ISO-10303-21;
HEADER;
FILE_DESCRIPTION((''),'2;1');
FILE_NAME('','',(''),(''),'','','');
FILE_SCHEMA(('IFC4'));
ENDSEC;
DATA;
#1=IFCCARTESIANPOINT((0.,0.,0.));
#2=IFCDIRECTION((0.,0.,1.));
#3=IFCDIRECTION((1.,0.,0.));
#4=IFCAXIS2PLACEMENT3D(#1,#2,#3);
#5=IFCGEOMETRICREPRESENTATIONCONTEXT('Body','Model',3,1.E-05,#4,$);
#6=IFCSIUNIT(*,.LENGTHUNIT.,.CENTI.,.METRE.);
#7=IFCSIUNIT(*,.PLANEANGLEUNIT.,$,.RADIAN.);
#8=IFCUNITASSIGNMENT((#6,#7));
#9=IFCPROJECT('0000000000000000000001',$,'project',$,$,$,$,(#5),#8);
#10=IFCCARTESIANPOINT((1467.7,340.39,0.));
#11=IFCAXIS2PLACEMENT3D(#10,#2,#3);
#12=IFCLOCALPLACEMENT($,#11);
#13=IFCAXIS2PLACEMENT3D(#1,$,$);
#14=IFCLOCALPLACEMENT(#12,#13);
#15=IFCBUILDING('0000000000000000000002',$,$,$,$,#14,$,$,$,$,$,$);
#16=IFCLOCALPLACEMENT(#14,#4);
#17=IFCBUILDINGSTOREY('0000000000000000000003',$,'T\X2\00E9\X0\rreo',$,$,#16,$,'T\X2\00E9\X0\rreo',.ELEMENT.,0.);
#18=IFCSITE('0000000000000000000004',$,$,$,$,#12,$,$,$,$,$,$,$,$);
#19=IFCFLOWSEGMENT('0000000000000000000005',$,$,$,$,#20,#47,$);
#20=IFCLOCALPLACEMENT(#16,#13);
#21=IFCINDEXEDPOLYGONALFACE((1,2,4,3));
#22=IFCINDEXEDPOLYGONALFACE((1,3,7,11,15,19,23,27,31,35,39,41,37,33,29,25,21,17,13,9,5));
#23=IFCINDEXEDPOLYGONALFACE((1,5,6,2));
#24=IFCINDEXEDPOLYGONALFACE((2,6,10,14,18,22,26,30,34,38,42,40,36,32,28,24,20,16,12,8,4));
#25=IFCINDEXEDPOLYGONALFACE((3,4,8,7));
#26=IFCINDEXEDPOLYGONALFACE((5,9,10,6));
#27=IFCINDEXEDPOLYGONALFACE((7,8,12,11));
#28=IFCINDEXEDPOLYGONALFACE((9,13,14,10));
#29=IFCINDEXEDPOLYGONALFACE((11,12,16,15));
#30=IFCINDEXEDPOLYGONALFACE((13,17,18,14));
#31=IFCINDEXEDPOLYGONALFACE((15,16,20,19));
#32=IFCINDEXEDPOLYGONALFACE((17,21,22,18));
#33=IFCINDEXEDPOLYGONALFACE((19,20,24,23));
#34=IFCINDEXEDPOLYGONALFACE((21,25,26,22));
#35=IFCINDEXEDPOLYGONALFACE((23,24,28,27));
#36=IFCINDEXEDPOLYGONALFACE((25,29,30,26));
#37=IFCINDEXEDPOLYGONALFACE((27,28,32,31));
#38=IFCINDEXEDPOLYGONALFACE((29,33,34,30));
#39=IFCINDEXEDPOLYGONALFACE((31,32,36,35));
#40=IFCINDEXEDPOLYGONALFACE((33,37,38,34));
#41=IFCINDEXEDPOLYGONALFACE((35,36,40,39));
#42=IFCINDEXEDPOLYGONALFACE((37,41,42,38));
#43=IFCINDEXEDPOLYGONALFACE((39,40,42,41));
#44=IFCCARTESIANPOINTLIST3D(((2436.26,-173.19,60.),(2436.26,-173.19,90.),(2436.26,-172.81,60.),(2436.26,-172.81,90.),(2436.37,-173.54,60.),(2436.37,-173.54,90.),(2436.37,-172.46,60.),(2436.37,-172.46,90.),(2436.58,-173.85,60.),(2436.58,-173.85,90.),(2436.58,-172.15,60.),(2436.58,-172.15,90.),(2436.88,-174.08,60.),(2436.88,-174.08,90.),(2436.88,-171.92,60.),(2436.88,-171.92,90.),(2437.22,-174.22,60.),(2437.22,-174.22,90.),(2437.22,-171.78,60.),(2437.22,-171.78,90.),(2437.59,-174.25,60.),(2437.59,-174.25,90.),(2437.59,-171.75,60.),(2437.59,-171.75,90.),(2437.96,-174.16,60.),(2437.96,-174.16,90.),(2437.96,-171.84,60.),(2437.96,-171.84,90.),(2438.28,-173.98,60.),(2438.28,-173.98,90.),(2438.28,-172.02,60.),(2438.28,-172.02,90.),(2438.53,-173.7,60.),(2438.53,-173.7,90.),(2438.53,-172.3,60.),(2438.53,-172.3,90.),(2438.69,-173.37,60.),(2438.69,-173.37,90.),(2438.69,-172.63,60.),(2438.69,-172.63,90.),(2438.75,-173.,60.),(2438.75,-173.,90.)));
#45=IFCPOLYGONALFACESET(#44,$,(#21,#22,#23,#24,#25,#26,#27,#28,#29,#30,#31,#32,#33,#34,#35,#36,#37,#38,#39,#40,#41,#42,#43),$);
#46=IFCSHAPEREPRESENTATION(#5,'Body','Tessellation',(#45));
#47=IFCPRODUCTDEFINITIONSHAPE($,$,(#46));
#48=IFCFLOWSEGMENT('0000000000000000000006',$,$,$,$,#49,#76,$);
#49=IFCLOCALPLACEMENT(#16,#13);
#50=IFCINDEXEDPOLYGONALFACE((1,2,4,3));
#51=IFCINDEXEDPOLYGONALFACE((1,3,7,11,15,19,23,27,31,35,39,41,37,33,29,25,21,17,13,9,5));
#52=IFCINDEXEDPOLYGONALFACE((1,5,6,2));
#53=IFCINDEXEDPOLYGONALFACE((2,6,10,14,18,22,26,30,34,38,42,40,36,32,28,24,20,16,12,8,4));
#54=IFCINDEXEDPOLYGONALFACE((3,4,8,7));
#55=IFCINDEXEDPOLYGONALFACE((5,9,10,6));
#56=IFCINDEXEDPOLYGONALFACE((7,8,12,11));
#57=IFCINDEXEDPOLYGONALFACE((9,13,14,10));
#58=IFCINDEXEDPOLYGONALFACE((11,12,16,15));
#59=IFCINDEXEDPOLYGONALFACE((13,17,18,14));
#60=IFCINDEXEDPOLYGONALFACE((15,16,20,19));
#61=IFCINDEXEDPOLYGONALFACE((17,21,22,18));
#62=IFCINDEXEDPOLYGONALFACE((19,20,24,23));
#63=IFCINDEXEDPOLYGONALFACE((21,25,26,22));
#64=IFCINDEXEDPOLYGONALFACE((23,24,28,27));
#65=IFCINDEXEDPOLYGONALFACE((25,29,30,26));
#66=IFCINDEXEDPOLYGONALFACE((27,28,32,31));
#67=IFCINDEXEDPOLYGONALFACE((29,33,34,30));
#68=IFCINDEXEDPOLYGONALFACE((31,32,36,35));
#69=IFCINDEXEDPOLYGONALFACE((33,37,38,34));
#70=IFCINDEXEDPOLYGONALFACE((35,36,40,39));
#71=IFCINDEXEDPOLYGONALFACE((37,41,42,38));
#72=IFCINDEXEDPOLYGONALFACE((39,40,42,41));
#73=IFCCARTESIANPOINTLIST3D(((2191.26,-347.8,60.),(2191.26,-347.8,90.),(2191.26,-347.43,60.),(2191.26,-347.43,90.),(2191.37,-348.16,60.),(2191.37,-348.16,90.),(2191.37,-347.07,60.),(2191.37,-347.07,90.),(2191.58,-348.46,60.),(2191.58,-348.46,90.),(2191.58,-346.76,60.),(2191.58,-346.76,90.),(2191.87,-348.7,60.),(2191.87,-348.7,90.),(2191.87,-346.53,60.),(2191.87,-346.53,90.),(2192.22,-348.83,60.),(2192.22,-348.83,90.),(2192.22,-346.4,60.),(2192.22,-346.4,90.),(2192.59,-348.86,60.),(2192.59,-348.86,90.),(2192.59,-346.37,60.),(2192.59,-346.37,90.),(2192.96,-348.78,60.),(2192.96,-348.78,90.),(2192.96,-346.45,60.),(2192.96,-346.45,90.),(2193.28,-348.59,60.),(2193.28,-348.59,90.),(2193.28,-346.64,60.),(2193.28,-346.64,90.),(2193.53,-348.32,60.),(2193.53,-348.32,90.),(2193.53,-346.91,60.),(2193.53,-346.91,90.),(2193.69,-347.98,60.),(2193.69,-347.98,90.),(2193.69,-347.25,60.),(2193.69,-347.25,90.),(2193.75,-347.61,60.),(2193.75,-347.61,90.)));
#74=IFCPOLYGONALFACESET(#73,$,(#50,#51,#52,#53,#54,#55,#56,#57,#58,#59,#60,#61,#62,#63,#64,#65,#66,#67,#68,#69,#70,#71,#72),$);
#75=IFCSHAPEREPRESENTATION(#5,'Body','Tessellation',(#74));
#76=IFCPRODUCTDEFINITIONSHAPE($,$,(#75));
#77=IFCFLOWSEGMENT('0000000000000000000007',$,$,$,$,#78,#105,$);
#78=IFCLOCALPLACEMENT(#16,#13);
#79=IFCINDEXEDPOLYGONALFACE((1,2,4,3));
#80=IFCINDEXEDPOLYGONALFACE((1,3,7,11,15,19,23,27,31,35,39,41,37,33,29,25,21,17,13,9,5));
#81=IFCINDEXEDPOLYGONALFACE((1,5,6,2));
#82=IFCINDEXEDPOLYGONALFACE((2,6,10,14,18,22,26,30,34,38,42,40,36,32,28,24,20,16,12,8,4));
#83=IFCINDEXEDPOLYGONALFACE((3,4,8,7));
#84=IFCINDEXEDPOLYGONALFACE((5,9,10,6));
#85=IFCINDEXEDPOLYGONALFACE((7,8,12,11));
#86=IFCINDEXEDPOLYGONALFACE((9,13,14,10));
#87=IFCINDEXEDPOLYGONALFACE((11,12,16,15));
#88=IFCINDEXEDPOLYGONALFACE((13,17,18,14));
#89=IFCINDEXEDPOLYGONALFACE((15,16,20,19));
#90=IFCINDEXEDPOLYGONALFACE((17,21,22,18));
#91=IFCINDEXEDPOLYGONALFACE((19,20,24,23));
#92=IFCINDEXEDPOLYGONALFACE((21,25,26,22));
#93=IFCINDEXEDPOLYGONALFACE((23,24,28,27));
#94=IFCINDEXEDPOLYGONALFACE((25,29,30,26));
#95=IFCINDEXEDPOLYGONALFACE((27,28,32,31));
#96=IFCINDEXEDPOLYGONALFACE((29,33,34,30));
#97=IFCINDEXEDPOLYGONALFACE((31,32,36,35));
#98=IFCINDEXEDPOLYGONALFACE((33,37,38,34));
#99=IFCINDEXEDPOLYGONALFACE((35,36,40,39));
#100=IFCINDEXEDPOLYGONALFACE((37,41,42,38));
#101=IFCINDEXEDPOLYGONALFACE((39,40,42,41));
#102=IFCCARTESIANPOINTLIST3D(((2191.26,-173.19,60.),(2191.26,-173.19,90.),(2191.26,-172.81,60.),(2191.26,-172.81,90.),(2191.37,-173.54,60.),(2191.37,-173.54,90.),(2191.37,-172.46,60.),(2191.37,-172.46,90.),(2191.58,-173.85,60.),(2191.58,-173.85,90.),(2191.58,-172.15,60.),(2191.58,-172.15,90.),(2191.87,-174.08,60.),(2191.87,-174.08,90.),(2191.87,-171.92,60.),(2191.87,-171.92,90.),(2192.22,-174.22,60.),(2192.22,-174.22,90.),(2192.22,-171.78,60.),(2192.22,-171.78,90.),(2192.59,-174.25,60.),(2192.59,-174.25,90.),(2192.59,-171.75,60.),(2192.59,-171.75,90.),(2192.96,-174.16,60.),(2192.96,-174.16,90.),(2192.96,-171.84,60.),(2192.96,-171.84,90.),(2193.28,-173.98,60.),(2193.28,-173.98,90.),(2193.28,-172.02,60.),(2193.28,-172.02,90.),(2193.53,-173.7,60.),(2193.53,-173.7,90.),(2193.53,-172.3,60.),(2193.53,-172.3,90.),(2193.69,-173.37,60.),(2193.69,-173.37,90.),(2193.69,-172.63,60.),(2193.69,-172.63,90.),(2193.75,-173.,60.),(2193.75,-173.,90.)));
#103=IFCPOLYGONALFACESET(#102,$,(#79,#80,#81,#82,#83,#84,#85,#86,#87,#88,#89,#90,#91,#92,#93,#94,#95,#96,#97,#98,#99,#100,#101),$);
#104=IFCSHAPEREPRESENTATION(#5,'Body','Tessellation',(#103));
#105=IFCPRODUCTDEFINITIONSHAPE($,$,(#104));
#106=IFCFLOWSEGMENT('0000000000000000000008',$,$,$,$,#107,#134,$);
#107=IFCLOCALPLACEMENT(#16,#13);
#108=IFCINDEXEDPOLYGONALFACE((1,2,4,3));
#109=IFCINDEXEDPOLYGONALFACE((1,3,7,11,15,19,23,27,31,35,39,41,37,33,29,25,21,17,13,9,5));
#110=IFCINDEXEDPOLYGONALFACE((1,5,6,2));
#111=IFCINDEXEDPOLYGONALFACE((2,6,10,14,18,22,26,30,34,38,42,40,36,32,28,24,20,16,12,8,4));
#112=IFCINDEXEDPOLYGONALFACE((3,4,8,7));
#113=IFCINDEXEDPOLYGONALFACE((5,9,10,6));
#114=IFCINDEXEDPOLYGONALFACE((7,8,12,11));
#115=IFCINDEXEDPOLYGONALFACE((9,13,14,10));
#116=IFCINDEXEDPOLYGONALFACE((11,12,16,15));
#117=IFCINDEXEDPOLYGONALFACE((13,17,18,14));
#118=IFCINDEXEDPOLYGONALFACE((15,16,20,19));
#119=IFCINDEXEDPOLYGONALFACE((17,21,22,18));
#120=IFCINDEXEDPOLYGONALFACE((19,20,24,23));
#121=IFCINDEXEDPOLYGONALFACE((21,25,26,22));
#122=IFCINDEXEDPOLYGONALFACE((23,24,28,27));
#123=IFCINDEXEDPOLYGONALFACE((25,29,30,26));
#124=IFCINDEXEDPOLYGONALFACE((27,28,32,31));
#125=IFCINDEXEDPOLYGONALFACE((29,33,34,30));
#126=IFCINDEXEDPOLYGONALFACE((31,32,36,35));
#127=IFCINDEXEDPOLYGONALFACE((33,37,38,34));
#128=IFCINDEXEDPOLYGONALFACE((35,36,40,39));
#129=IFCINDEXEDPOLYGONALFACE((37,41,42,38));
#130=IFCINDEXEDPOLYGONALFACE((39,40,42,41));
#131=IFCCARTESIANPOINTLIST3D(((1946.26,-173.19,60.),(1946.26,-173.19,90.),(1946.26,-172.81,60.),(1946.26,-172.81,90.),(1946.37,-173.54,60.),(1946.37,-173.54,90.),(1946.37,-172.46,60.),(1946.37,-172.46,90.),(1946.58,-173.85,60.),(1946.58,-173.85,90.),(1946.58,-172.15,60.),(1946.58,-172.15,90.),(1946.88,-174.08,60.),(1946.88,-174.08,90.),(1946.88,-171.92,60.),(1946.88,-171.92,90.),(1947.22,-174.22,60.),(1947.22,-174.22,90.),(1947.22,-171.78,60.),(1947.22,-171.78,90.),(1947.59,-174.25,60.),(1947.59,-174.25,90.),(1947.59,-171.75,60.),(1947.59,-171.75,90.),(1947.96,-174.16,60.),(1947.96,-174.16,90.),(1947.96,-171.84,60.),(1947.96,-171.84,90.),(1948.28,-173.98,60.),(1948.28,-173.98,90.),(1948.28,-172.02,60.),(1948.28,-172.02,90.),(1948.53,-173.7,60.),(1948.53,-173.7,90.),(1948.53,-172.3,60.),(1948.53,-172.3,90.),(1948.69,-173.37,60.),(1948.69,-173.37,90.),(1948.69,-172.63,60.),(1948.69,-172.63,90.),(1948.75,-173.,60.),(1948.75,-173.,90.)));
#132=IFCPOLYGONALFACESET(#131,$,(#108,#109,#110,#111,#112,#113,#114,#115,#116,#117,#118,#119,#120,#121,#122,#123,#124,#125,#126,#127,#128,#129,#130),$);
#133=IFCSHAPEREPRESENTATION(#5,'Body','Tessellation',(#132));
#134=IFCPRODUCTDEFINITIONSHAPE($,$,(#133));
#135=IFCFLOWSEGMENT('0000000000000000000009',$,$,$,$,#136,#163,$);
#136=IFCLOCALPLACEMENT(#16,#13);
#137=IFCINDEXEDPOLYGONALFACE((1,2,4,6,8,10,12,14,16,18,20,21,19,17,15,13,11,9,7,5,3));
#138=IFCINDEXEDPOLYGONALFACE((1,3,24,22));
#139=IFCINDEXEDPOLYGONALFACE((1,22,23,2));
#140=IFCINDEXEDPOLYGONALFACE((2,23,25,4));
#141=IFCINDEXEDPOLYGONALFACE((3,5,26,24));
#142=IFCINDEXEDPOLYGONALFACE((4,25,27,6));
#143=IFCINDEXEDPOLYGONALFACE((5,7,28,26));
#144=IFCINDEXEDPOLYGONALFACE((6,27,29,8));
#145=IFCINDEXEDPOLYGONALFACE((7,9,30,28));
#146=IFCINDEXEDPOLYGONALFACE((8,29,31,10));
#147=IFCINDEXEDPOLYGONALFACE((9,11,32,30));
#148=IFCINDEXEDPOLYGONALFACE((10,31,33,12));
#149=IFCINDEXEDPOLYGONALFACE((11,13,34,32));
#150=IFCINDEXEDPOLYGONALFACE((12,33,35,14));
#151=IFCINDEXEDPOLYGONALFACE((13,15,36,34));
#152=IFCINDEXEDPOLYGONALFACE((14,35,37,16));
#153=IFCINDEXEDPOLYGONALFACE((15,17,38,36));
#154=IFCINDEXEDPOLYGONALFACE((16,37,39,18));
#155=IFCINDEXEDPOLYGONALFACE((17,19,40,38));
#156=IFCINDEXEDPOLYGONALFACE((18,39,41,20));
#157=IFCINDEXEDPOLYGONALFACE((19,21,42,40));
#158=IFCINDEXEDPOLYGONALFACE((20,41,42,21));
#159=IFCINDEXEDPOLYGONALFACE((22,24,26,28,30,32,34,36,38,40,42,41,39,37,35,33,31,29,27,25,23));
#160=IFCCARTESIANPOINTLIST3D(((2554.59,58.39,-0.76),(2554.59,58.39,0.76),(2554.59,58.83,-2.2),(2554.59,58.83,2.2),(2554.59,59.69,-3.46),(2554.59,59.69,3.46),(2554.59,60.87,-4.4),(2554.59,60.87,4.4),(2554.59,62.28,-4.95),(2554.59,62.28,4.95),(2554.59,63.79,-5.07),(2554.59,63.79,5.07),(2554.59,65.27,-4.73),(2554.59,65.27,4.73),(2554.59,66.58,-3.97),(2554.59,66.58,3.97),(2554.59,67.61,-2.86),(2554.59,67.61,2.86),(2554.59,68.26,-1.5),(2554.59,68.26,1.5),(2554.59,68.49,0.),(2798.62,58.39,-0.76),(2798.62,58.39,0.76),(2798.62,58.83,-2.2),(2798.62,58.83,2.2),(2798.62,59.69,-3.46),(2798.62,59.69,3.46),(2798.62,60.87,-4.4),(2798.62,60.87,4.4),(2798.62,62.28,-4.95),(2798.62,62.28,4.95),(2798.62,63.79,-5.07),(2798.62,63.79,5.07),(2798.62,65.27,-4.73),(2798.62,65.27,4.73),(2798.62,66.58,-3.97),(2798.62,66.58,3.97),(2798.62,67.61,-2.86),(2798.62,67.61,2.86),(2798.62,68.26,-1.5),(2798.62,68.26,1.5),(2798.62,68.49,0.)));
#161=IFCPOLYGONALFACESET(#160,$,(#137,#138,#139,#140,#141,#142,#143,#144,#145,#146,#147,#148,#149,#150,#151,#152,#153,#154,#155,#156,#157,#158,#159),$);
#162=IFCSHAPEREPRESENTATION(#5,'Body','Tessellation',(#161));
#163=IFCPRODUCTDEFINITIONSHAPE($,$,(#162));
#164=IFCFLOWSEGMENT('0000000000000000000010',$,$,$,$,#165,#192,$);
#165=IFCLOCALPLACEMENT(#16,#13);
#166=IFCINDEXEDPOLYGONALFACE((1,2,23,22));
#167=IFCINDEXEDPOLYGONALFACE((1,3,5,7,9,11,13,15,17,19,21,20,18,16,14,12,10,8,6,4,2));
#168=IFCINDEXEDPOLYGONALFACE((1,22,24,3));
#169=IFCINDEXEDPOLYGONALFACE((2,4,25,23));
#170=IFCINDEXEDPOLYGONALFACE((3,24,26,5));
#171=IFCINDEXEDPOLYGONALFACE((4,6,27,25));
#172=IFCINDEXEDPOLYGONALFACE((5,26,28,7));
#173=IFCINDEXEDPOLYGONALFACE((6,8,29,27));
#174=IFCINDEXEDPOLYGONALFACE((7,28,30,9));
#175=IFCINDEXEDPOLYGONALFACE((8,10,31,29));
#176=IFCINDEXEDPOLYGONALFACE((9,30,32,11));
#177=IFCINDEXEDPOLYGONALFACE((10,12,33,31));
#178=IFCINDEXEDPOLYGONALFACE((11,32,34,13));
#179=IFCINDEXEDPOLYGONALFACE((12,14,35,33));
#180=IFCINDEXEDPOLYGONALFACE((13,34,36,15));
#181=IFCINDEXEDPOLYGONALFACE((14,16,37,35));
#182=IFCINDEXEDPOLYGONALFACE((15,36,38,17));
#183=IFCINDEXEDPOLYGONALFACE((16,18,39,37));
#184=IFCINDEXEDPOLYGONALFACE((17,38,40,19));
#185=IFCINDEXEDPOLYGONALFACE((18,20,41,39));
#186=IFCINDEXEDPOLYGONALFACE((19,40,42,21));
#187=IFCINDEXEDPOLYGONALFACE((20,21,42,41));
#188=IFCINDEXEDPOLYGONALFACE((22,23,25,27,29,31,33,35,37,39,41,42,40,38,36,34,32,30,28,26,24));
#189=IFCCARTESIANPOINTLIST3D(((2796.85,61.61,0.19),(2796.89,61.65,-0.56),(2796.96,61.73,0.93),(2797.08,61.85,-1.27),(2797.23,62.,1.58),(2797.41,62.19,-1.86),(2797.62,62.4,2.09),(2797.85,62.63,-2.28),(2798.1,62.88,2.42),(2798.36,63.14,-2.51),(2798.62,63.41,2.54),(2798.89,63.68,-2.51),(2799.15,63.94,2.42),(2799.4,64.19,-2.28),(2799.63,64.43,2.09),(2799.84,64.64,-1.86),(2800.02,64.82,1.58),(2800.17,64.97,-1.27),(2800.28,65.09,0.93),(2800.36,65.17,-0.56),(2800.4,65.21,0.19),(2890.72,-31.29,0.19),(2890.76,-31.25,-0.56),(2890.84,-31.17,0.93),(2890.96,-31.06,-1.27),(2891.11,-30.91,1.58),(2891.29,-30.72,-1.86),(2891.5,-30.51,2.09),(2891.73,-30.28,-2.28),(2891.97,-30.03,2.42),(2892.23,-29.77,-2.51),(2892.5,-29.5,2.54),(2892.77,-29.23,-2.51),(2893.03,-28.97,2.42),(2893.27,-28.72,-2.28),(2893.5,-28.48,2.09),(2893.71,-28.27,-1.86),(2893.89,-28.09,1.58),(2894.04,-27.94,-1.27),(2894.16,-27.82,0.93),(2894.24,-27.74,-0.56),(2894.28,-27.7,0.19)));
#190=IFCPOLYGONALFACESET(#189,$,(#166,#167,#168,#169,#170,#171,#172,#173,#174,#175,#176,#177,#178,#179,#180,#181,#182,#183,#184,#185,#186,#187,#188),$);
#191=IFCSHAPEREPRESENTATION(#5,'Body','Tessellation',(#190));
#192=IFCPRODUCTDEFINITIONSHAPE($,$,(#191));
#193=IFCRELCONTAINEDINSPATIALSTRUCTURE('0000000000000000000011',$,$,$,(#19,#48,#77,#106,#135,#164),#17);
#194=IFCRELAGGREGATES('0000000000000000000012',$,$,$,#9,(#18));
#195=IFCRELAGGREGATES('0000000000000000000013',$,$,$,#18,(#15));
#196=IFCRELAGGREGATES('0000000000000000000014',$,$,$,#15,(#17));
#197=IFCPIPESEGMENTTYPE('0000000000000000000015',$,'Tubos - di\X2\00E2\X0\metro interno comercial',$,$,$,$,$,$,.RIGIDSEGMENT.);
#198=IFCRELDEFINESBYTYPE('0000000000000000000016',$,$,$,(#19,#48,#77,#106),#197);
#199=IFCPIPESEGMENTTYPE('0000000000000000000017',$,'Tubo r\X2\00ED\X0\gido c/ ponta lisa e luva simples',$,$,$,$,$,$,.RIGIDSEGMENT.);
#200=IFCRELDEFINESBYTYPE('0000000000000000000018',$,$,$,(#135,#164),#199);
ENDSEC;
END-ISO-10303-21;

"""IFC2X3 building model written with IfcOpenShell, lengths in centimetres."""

from ifc_helpers import new_model, si_unit, frame, origin, origin_with_axes, origin_2d_with_axis, place, context, project, spatial, circle, extrude, type_object, element, save


model = new_model("IFC2X3")

# Units and contexts
model_context = context("Model", 3, precision=1e-05, world=origin_with_axes(), identifier="Body")
ifc_project = project(units=[si_unit("LENGTHUNIT", "METRE", prefix="CENTI"), si_unit("PLANEANGLEUNIT", "RADIAN")], contexts=[model_context])

# Site, building, storey
site_placement = place(None, frame((1467.7, 340.39, 0.0), z_axis=(0.0, 0.0, 1.0), x_axis=(1.0, 0.0, 0.0)))
site = spatial("IfcSite", under=ifc_project, at=site_placement)
building_placement = place(site_placement, origin())
building = spatial("IfcBuilding", under=site, at=building_placement)
storey_placement = place(building_placement, origin_with_axes())
storey = spatial("IfcBuildingStorey", under=building, at=storey_placement, Name="Térreo", LongName="Térreo", CompositionType="ELEMENT", Elevation=0.0)

# Flow segments
pipe_segment_type_1 = type_object("IfcPipeSegmentType", Name="Tubos - diâmetro interno comercial", PredefinedType="RIGIDSEGMENT")
for number, where, z_axis, x_axis in (
    (1, (2437.5, -173.0, 90.0), (0.0, 0.0, 1.0), (1.0, 0.0, 0.0)),
    (2, (2192.5, -347.61, 90.0), (0.0, 0.0, 1.0), (1.0, 0.0, 0.0)),
    (3, (2192.5, -173.0, 90.0), (0.0, 0.0, 1.0), (1.0, 0.0, 0.0)),
    (4, (1947.5, -173.0, 90.0), (0.0, 0.0, 1.0), (1.0, 0.0, 0.0)),
):
    element("IfcFlowSegment", number, at=place(storey_placement, frame(where, z_axis=z_axis, x_axis=x_axis)), inside=storey, type_object=pipe_segment_type_1, context=model_context, shape_type="SolidModel", body=[
        extrude(circle(Radius=1.25, at=origin_2d_with_axis()), frame((0.0, 0.0, 0.0), z_axis=(0.0, 0.0, -1.0), x_axis=(1.0, 0.0, 0.0)), (0.0, 0.0, 1.0), 30.0),
    ])
pipe_segment_type_2 = type_object("IfcPipeSegmentType", Name="Tubo rígido c/ ponta lisa e luva simples", PredefinedType="RIGIDSEGMENT")
flow_segment_1_placement = place(storey_placement, frame((2676.61, 63.41, 5.08), z_axis=(0.0, 0.0, 1.0), x_axis=(1.0, 0.0, 0.0)))
element("IfcFlowSegment", 5, at=flow_segment_1_placement, inside=storey, type_object=pipe_segment_type_2, context=model_context, shape_type="SolidModel", body=[
    extrude(circle(Radius=5.08, at=origin_2d_with_axis()), frame((122.02, 0.0, -5.08), z_axis=(-1.0, 0.0, 0.0), x_axis=(0.0, 1.0, 0.0)), (0.0, 0.0, 1.0), 244.03),
])
flow_segment_2_placement = place(storey_placement, frame((2845.56, 16.96, 2.54), z_axis=(0.0, 0.0, 1.0), x_axis=(1.0, 0.0, 0.0)))
element("IfcFlowSegment", 6, at=flow_segment_2_placement, inside=storey, type_object=pipe_segment_type_2, context=model_context, shape_type="SolidModel", body=[
    extrude(circle(Radius=2.54, at=origin_2d_with_axis()), frame((46.94, -46.45, -2.54), z_axis=(-0.71076, 0.703434, 0.0), x_axis=(0.0, 0.0, 1.0)), (0.0, 0.0, 1.0), 132.08),
])

save(model, "model.ifc")
